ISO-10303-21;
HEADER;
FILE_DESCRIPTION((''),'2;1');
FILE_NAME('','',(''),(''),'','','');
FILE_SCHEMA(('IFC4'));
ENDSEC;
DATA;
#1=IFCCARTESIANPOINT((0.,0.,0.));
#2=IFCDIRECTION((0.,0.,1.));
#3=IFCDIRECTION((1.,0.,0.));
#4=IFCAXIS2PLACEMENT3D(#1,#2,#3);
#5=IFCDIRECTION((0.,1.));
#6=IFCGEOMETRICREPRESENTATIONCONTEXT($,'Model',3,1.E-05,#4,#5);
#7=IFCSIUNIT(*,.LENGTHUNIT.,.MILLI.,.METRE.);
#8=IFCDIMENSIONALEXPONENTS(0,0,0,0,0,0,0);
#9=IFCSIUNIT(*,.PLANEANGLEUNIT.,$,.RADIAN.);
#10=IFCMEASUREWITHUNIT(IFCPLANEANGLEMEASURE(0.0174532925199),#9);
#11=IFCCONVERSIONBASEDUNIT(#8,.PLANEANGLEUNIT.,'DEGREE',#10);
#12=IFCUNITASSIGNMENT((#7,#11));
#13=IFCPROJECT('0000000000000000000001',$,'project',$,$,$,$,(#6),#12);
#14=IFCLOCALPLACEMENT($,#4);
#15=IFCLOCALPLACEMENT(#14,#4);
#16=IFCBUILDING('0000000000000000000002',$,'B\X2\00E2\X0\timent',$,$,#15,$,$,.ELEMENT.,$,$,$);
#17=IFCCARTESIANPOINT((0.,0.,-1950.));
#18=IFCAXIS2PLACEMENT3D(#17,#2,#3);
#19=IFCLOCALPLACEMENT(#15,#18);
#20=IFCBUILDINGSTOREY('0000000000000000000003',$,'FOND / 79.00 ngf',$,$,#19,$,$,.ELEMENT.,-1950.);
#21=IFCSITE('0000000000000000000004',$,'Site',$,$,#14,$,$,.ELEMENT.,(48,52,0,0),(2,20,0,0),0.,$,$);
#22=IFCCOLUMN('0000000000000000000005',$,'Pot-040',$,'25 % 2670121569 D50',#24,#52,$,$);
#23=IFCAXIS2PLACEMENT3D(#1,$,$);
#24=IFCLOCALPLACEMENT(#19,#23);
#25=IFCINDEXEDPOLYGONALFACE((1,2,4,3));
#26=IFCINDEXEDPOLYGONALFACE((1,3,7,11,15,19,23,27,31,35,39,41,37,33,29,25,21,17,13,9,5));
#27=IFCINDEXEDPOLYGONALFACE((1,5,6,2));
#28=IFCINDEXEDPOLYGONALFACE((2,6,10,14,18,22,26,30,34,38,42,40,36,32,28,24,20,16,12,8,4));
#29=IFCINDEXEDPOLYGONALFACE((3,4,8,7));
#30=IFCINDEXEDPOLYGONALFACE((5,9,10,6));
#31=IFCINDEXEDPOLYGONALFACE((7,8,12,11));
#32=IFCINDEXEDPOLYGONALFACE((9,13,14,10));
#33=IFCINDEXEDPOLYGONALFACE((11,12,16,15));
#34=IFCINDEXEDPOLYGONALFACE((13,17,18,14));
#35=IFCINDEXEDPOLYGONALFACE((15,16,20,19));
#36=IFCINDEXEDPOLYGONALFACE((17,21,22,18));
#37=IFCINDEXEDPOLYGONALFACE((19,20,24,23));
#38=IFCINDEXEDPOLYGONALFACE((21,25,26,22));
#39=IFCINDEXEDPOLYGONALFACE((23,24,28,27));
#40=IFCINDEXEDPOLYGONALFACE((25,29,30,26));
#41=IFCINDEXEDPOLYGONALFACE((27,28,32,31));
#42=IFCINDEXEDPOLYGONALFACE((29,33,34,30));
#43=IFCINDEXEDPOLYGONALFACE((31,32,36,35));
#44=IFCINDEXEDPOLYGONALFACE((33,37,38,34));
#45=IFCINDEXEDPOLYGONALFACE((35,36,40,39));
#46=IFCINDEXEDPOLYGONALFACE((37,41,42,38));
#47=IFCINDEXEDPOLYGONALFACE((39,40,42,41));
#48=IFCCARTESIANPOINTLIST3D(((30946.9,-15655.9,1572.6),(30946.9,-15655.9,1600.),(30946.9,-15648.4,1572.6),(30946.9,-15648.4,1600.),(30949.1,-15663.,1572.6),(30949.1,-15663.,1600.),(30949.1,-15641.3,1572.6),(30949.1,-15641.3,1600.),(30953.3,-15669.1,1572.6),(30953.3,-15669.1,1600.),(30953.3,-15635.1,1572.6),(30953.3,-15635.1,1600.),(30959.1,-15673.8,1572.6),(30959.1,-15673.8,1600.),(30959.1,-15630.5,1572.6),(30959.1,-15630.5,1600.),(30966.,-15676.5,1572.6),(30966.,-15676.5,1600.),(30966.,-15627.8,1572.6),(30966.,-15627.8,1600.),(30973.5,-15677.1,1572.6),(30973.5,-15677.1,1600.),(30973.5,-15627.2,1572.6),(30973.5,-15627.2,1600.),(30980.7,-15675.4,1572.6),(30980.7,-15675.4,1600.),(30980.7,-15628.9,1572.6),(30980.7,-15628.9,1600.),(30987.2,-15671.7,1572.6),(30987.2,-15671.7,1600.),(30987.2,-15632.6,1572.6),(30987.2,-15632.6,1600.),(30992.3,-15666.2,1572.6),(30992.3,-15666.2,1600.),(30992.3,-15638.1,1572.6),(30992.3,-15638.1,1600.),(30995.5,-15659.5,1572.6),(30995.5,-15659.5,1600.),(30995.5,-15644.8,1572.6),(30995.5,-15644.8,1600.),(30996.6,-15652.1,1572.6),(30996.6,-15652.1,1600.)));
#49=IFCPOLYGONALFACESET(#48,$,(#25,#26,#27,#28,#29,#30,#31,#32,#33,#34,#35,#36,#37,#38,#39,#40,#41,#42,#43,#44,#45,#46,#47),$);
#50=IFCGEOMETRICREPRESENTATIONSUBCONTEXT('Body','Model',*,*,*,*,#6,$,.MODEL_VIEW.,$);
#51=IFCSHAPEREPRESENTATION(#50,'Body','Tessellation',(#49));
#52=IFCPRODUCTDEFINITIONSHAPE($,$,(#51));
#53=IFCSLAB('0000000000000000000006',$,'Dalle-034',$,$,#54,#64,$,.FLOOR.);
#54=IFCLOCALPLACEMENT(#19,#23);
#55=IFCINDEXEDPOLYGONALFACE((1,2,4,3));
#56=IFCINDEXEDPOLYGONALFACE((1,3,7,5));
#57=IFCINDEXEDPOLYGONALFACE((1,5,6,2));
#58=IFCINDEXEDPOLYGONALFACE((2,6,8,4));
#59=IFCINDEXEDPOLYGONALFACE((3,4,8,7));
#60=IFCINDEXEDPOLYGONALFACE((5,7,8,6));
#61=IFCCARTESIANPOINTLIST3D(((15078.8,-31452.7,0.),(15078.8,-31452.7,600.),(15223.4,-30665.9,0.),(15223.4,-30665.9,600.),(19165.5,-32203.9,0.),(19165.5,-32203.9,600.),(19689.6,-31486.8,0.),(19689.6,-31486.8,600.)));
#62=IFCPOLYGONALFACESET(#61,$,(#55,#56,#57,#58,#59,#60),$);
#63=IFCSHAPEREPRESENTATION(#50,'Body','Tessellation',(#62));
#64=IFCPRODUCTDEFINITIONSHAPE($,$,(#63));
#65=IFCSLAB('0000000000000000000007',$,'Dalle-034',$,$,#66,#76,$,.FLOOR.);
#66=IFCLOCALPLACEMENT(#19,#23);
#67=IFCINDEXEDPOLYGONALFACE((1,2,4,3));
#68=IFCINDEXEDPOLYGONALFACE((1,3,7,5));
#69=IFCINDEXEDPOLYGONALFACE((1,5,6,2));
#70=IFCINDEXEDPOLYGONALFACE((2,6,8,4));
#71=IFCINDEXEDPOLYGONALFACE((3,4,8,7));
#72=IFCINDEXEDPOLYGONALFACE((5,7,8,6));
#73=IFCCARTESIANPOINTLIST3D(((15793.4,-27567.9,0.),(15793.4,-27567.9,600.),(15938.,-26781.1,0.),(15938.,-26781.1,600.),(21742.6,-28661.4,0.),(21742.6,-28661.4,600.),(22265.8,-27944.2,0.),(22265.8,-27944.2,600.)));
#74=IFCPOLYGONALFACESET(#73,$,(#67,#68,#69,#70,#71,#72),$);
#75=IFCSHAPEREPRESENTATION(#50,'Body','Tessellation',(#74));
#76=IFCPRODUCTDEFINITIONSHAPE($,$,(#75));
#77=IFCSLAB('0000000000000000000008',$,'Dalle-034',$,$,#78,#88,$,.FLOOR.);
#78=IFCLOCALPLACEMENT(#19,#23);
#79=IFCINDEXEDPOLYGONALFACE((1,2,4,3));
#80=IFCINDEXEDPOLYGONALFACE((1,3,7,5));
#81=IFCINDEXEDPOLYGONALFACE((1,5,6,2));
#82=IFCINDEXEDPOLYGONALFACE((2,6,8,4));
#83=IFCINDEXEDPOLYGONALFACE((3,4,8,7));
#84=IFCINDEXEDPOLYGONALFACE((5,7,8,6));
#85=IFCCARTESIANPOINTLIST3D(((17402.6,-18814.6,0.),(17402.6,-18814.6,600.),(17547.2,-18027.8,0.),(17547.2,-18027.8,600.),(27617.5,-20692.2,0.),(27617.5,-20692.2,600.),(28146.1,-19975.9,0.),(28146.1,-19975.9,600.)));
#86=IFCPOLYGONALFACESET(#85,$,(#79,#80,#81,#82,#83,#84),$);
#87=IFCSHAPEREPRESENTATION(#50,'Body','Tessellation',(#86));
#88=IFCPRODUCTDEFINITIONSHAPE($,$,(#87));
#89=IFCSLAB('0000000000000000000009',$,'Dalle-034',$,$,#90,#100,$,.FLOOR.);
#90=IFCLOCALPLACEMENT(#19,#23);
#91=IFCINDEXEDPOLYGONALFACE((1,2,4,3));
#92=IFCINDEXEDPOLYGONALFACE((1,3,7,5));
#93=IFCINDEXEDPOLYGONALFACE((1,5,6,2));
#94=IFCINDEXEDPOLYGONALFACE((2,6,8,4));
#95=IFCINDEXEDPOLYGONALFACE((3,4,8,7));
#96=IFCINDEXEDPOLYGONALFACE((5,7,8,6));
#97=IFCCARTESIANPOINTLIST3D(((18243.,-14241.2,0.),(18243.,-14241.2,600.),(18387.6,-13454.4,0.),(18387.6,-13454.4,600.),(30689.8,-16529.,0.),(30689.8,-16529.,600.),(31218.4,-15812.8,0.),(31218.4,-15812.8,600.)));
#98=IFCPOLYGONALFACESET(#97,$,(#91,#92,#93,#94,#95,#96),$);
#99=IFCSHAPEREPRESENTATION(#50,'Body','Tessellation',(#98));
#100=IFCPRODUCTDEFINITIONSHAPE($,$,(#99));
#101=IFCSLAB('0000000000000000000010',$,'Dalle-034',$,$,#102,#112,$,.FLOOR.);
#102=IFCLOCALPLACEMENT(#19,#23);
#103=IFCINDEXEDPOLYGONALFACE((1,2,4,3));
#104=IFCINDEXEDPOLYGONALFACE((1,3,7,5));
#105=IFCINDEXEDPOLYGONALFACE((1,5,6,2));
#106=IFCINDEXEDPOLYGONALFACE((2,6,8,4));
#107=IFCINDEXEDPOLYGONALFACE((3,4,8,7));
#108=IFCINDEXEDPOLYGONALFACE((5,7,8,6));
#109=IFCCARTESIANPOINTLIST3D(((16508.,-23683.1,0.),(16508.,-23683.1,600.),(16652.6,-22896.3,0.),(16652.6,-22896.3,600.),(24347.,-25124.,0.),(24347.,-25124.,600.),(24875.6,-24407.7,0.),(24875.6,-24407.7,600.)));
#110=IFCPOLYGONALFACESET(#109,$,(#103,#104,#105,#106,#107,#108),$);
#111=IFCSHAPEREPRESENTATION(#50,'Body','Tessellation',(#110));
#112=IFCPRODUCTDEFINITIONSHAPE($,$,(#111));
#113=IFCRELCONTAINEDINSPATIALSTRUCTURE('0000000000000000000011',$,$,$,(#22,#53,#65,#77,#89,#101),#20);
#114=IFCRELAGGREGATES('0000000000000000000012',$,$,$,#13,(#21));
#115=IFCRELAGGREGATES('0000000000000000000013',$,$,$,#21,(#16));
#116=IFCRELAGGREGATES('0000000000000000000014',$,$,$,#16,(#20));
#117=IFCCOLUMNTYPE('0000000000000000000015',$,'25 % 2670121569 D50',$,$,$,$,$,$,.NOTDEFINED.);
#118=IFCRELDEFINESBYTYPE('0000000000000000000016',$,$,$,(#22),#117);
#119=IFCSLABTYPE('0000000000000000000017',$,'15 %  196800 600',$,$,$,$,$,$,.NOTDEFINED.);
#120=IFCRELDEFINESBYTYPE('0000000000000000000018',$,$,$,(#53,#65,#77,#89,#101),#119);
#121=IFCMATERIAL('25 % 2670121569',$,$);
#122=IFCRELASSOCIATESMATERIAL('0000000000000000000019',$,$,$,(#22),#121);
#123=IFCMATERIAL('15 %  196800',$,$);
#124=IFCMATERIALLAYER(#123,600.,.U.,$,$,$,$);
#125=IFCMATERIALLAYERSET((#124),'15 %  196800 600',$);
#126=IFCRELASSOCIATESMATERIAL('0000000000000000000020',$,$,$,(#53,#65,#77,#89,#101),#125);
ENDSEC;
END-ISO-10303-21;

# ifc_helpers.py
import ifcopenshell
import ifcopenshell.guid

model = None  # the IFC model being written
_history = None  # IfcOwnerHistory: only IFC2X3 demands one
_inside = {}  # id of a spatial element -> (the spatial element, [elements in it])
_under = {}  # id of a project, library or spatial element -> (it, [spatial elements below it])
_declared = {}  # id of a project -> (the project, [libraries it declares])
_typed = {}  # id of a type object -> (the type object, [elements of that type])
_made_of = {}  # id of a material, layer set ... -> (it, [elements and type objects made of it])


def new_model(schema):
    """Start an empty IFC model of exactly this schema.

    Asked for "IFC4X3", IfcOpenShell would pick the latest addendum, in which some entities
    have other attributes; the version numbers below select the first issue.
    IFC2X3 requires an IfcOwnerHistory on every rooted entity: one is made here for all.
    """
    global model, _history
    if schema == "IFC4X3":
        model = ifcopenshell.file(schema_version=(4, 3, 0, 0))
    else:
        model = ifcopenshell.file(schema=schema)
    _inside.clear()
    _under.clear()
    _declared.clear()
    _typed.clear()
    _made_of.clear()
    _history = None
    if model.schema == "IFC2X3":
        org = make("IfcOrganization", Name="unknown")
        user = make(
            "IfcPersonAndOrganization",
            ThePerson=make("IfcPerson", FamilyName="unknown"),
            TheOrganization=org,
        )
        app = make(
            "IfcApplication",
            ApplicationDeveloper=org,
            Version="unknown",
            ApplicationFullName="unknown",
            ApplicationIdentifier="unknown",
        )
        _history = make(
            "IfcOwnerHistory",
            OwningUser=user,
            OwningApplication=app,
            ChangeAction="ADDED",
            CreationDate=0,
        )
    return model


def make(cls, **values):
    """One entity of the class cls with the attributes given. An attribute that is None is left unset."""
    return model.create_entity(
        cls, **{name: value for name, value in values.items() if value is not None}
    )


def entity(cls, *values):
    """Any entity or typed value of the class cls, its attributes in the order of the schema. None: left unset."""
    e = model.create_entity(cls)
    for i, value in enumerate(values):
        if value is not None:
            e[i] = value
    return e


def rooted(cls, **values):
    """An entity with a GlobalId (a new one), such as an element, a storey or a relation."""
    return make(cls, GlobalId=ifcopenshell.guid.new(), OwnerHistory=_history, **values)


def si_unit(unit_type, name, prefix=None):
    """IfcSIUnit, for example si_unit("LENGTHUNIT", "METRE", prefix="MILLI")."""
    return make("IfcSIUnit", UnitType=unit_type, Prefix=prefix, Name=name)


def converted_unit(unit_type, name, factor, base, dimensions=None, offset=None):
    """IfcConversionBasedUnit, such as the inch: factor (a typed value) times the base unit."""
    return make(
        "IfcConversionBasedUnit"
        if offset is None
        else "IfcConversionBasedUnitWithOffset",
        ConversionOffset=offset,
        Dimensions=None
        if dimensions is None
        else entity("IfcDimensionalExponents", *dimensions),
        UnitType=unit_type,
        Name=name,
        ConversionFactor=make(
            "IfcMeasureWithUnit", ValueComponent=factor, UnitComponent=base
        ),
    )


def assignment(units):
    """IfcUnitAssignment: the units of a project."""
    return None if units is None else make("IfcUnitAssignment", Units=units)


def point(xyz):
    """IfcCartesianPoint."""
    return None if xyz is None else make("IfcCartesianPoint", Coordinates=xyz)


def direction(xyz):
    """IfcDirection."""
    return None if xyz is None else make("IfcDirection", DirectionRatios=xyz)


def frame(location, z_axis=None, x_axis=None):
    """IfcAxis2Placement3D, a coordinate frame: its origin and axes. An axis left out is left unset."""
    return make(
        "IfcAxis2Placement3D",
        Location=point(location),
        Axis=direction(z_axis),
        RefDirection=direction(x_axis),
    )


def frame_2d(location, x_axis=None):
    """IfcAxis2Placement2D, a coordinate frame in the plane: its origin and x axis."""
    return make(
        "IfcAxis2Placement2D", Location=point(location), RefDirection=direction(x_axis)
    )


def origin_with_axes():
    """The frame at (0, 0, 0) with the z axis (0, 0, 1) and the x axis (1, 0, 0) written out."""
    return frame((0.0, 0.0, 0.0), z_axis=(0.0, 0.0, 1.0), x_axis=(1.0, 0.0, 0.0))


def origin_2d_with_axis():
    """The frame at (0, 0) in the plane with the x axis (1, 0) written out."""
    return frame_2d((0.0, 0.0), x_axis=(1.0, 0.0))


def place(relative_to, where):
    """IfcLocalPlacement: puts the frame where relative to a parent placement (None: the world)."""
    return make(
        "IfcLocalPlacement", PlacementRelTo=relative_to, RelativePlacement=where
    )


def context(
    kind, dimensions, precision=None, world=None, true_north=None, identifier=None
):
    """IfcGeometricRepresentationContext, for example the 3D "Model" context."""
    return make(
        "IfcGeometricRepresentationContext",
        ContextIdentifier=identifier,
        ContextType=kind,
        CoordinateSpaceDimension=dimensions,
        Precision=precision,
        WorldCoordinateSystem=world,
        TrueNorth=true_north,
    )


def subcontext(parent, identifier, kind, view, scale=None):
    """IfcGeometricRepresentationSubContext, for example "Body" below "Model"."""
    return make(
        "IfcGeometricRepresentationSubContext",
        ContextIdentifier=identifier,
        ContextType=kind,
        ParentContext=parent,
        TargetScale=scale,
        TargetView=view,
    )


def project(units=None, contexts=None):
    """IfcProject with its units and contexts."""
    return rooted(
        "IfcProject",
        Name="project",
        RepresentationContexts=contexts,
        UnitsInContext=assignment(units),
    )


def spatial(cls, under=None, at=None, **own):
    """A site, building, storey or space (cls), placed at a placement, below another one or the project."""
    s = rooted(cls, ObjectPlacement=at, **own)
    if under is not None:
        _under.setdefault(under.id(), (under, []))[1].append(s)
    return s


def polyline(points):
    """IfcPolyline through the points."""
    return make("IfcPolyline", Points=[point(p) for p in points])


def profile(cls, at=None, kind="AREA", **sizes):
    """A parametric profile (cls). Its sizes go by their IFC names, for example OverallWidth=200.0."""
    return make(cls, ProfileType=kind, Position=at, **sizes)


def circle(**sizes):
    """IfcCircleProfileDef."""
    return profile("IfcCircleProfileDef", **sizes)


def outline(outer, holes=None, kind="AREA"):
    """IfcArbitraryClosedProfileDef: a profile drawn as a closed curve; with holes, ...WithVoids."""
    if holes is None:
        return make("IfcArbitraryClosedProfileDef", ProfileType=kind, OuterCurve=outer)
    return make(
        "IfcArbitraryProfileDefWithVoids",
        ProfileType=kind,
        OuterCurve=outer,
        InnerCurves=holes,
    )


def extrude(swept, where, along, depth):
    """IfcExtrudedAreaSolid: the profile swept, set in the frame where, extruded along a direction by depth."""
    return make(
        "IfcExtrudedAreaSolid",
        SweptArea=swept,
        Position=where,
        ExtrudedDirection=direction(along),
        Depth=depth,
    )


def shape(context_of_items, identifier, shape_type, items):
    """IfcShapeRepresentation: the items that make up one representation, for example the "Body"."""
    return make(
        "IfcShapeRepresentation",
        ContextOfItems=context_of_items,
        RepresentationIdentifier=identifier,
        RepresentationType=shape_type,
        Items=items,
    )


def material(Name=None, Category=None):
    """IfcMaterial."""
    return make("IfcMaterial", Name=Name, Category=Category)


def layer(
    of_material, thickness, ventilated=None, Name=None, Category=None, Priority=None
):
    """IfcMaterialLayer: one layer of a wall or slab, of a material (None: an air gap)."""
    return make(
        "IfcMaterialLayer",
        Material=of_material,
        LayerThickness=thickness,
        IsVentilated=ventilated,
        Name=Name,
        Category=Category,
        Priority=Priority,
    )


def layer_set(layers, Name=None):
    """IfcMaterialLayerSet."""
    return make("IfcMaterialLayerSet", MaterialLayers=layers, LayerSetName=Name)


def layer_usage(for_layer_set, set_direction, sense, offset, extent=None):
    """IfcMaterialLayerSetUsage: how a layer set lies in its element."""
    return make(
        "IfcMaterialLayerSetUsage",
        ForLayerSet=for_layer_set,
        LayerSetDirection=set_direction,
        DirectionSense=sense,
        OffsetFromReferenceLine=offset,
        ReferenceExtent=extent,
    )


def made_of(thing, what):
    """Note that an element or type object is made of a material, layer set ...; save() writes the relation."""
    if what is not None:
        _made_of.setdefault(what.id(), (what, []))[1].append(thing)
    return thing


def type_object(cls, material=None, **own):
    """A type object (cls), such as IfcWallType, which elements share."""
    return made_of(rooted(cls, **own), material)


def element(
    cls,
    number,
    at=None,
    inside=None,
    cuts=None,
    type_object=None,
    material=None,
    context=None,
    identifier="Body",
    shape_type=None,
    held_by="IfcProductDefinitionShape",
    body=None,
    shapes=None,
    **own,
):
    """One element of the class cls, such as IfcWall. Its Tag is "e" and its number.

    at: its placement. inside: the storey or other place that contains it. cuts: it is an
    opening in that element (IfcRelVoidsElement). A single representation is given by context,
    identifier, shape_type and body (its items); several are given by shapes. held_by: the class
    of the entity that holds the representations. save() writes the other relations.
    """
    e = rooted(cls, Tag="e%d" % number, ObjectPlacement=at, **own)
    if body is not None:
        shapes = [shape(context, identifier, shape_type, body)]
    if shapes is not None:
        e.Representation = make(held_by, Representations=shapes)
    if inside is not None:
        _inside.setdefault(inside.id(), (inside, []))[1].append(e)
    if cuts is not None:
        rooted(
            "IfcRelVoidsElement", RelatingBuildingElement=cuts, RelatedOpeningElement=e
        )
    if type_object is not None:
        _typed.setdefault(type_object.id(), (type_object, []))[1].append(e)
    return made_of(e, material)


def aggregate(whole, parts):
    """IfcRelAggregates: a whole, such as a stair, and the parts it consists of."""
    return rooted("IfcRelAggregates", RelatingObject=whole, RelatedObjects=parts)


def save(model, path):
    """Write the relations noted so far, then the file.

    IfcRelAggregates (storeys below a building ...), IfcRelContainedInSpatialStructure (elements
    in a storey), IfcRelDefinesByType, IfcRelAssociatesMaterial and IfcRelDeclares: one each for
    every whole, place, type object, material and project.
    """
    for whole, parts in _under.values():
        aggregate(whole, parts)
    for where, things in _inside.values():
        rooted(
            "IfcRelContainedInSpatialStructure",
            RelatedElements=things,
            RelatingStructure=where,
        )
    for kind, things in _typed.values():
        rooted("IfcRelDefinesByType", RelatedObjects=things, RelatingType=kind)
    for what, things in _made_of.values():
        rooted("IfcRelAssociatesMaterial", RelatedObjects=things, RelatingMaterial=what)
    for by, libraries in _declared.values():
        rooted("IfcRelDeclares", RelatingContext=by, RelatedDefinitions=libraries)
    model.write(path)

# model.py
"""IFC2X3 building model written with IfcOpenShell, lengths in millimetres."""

from ifc_helpers import new_model, entity, si_unit, converted_unit, direction, frame, origin_with_axes, origin_2d_with_axis, place, context, subcontext, project, spatial, polyline, circle, outline, extrude, material, layer, layer_set, layer_usage, type_object, element, save


model = new_model("IFC2X3")

# Units and contexts
model_context = context("Model", 3, precision=1e-05, world=origin_with_axes(), true_north=direction((0.0, 1.0)))
body_context = subcontext(model_context, "Body", "Model", "MODEL_VIEW")
ifc_project = project(units=[si_unit("LENGTHUNIT", "METRE", prefix="MILLI"), converted_unit("PLANEANGLEUNIT", "DEGREE", entity("IfcPlaneAngleMeasure", 0.0174532925199), si_unit("PLANEANGLEUNIT", "RADIAN"), dimensions=[0, 0, 0, 0, 0, 0, 0])], contexts=[model_context])

# Site, building, storey
site_placement = place(None, origin_with_axes())
site = spatial("IfcSite", under=ifc_project, at=site_placement, Name="Site", CompositionType="ELEMENT", RefLatitude=(48, 52, 0, 0), RefLongitude=(2, 20, 0, 0), RefElevation=0.0)
building_placement = place(site_placement, origin_with_axes())
building = spatial("IfcBuilding", under=site, at=building_placement, Name="Bâtiment", CompositionType="ELEMENT")
storey_placement = place(building_placement, frame((0.0, 0.0, -1950.0), z_axis=(0.0, 0.0, 1.0), x_axis=(1.0, 0.0, 0.0)))
storey = spatial("IfcBuildingStorey", under=building, at=storey_placement, Name="FOND / 79.00 ngf", CompositionType="ELEMENT", Elevation=-1950.0)

# Column
ifc_material_1 = material(Name="25 % 2670121569")
column_type = type_object("IfcColumnType", Name="25 % 2670121569 D50", PredefinedType="NOTDEFINED")
column_placement = place(storey_placement, frame((30971.6, -15652.1, 1572.6), z_axis=(0.0, 0.0, 1.0), x_axis=(1.0, 0.0, 0.0)))
element("IfcColumn", 1, at=column_placement, inside=storey, type_object=column_type, material=ifc_material_1, Name="Pot-040", ObjectType="25 % 2670121569 D50", context=body_context, shape_type="SweptSolid", body=[
    extrude(circle(Radius=25.0, at=origin_2d_with_axis()), origin_with_axes(), (0.0, 0.0, 1.0), 27.4),
])

# Slabs
ifc_material_2 = material(Name="15 %  196800")
ifc_layer_1 = layer(ifc_material_2, 600.0, ventilated="UNKNOWN")
ifc_layer_set_1 = layer_set([ifc_layer_1], Name="15 %  196800 600")
ifc_layer_usage_1 = layer_usage(ifc_layer_set_1, "AXIS3", "NEGATIVE", 600.0)
slab_type_1 = type_object("IfcSlabType", Name="15 %  196800 600", PredefinedType="NOTDEFINED")
slab_1_placement = place(storey_placement, frame((15223.4, -30665.9, 600.0), z_axis=(0.0, 0.0, 1.0), x_axis=(1.0, 0.0, 0.0)))
element("IfcSlab", 2, at=slab_1_placement, inside=storey, type_object=slab_type_1, material=ifc_layer_usage_1, Name="Dalle-034", PredefinedType="FLOOR", context=body_context, shape_type="SweptSolid", body=[
    extrude(outline(polyline([(0.0, 0.0), (-144.6, -786.8), (3942.1, -1538.0), (4466.2, -820.9), (0.0, 0.0)])), frame((0.0, 0.0, -600.0), z_axis=(0.0, 0.0, 1.0), x_axis=(1.0, 0.0, 0.0)), (0.0, 0.0, 1.0), 600.0),
])
ifc_layer_usage_2 = layer_usage(ifc_layer_set_1, "AXIS3", "NEGATIVE", 600.0)
slab_2_placement = place(storey_placement, frame((15938.0, -26781.1, 600.0), z_axis=(0.0, 0.0, 1.0), x_axis=(1.0, 0.0, 0.0)))
element("IfcSlab", 3, at=slab_2_placement, inside=storey, type_object=slab_type_1, material=ifc_layer_usage_2, Name="Dalle-034", PredefinedType="FLOOR", context=body_context, shape_type="SweptSolid", body=[
    extrude(outline(polyline([(0.0, 0.0), (-144.6, -786.8), (5804.5, -1880.3), (6327.8, -1163.1), (0.0, 0.0)])), frame((0.0, 0.0, -600.0), z_axis=(0.0, 0.0, 1.0), x_axis=(1.0, 0.0, 0.0)), (0.0, 0.0, 1.0), 600.0),
])
ifc_layer_usage_3 = layer_usage(ifc_layer_set_1, "AXIS3", "NEGATIVE", 600.0)
slab_3_placement = place(storey_placement, frame((17547.2, -18027.8, 600.0), z_axis=(0.0, 0.0, 1.0), x_axis=(1.0, 0.0, 0.0)))
element("IfcSlab", 4, at=slab_3_placement, inside=storey, type_object=slab_type_1, material=ifc_layer_usage_3, Name="Dalle-034", PredefinedType="FLOOR", context=body_context, shape_type="SweptSolid", body=[
    extrude(outline(polyline([(0.0, 0.0), (-144.6, -786.8), (10070.3, -2664.4), (10598.9, -1948.2), (0.0, 0.0)])), frame((0.0, 0.0, -600.0), z_axis=(0.0, 0.0, 1.0), x_axis=(1.0, 0.0, 0.0)), (0.0, 0.0, 1.0), 600.0),
])
ifc_layer_usage_4 = layer_usage(ifc_layer_set_1, "AXIS3", "NEGATIVE", 600.0)
slab_4_placement = place(storey_placement, frame((18387.6, -13454.4, 600.0), z_axis=(0.0, 0.0, 1.0), x_axis=(1.0, 0.0, 0.0)))
element("IfcSlab", 5, at=slab_4_placement, inside=storey, type_object=slab_type_1, material=ifc_layer_usage_4, Name="Dalle-034", PredefinedType="FLOOR", context=body_context, shape_type="SweptSolid", body=[
    extrude(outline(polyline([(0.0, 0.0), (-144.6, -786.8), (12302.2, -3074.7), (12830.8, -2358.4), (0.0, 0.0)])), frame((0.0, 0.0, -600.0), z_axis=(0.0, 0.0, 1.0), x_axis=(1.0, 0.0, 0.0)), (0.0, 0.0, 1.0), 600.0),
])
ifc_layer_usage_5 = layer_usage(ifc_layer_set_1, "AXIS3", "NEGATIVE", 600.0)
slab_5_placement = place(storey_placement, frame((16652.6, -22896.3, 600.0), z_axis=(0.0, 0.0, 1.0), x_axis=(1.0, 0.0, 0.0)))
element("IfcSlab", 6, at=slab_5_placement, inside=storey, type_object=slab_type_1, material=ifc_layer_usage_5, Name="Dalle-034", PredefinedType="FLOOR", context=body_context, shape_type="SweptSolid", body=[
    extrude(outline(polyline([(0.0, 0.0), (-144.6, -786.8), (7694.4, -2227.7), (8223.0, -1511.5), (0.0, 0.0)])), frame((0.0, 0.0, -600.0), z_axis=(0.0, 0.0, 1.0), x_axis=(1.0, 0.0, 0.0)), (0.0, 0.0, 1.0), 600.0),
])

save(model, "model.ifc")
